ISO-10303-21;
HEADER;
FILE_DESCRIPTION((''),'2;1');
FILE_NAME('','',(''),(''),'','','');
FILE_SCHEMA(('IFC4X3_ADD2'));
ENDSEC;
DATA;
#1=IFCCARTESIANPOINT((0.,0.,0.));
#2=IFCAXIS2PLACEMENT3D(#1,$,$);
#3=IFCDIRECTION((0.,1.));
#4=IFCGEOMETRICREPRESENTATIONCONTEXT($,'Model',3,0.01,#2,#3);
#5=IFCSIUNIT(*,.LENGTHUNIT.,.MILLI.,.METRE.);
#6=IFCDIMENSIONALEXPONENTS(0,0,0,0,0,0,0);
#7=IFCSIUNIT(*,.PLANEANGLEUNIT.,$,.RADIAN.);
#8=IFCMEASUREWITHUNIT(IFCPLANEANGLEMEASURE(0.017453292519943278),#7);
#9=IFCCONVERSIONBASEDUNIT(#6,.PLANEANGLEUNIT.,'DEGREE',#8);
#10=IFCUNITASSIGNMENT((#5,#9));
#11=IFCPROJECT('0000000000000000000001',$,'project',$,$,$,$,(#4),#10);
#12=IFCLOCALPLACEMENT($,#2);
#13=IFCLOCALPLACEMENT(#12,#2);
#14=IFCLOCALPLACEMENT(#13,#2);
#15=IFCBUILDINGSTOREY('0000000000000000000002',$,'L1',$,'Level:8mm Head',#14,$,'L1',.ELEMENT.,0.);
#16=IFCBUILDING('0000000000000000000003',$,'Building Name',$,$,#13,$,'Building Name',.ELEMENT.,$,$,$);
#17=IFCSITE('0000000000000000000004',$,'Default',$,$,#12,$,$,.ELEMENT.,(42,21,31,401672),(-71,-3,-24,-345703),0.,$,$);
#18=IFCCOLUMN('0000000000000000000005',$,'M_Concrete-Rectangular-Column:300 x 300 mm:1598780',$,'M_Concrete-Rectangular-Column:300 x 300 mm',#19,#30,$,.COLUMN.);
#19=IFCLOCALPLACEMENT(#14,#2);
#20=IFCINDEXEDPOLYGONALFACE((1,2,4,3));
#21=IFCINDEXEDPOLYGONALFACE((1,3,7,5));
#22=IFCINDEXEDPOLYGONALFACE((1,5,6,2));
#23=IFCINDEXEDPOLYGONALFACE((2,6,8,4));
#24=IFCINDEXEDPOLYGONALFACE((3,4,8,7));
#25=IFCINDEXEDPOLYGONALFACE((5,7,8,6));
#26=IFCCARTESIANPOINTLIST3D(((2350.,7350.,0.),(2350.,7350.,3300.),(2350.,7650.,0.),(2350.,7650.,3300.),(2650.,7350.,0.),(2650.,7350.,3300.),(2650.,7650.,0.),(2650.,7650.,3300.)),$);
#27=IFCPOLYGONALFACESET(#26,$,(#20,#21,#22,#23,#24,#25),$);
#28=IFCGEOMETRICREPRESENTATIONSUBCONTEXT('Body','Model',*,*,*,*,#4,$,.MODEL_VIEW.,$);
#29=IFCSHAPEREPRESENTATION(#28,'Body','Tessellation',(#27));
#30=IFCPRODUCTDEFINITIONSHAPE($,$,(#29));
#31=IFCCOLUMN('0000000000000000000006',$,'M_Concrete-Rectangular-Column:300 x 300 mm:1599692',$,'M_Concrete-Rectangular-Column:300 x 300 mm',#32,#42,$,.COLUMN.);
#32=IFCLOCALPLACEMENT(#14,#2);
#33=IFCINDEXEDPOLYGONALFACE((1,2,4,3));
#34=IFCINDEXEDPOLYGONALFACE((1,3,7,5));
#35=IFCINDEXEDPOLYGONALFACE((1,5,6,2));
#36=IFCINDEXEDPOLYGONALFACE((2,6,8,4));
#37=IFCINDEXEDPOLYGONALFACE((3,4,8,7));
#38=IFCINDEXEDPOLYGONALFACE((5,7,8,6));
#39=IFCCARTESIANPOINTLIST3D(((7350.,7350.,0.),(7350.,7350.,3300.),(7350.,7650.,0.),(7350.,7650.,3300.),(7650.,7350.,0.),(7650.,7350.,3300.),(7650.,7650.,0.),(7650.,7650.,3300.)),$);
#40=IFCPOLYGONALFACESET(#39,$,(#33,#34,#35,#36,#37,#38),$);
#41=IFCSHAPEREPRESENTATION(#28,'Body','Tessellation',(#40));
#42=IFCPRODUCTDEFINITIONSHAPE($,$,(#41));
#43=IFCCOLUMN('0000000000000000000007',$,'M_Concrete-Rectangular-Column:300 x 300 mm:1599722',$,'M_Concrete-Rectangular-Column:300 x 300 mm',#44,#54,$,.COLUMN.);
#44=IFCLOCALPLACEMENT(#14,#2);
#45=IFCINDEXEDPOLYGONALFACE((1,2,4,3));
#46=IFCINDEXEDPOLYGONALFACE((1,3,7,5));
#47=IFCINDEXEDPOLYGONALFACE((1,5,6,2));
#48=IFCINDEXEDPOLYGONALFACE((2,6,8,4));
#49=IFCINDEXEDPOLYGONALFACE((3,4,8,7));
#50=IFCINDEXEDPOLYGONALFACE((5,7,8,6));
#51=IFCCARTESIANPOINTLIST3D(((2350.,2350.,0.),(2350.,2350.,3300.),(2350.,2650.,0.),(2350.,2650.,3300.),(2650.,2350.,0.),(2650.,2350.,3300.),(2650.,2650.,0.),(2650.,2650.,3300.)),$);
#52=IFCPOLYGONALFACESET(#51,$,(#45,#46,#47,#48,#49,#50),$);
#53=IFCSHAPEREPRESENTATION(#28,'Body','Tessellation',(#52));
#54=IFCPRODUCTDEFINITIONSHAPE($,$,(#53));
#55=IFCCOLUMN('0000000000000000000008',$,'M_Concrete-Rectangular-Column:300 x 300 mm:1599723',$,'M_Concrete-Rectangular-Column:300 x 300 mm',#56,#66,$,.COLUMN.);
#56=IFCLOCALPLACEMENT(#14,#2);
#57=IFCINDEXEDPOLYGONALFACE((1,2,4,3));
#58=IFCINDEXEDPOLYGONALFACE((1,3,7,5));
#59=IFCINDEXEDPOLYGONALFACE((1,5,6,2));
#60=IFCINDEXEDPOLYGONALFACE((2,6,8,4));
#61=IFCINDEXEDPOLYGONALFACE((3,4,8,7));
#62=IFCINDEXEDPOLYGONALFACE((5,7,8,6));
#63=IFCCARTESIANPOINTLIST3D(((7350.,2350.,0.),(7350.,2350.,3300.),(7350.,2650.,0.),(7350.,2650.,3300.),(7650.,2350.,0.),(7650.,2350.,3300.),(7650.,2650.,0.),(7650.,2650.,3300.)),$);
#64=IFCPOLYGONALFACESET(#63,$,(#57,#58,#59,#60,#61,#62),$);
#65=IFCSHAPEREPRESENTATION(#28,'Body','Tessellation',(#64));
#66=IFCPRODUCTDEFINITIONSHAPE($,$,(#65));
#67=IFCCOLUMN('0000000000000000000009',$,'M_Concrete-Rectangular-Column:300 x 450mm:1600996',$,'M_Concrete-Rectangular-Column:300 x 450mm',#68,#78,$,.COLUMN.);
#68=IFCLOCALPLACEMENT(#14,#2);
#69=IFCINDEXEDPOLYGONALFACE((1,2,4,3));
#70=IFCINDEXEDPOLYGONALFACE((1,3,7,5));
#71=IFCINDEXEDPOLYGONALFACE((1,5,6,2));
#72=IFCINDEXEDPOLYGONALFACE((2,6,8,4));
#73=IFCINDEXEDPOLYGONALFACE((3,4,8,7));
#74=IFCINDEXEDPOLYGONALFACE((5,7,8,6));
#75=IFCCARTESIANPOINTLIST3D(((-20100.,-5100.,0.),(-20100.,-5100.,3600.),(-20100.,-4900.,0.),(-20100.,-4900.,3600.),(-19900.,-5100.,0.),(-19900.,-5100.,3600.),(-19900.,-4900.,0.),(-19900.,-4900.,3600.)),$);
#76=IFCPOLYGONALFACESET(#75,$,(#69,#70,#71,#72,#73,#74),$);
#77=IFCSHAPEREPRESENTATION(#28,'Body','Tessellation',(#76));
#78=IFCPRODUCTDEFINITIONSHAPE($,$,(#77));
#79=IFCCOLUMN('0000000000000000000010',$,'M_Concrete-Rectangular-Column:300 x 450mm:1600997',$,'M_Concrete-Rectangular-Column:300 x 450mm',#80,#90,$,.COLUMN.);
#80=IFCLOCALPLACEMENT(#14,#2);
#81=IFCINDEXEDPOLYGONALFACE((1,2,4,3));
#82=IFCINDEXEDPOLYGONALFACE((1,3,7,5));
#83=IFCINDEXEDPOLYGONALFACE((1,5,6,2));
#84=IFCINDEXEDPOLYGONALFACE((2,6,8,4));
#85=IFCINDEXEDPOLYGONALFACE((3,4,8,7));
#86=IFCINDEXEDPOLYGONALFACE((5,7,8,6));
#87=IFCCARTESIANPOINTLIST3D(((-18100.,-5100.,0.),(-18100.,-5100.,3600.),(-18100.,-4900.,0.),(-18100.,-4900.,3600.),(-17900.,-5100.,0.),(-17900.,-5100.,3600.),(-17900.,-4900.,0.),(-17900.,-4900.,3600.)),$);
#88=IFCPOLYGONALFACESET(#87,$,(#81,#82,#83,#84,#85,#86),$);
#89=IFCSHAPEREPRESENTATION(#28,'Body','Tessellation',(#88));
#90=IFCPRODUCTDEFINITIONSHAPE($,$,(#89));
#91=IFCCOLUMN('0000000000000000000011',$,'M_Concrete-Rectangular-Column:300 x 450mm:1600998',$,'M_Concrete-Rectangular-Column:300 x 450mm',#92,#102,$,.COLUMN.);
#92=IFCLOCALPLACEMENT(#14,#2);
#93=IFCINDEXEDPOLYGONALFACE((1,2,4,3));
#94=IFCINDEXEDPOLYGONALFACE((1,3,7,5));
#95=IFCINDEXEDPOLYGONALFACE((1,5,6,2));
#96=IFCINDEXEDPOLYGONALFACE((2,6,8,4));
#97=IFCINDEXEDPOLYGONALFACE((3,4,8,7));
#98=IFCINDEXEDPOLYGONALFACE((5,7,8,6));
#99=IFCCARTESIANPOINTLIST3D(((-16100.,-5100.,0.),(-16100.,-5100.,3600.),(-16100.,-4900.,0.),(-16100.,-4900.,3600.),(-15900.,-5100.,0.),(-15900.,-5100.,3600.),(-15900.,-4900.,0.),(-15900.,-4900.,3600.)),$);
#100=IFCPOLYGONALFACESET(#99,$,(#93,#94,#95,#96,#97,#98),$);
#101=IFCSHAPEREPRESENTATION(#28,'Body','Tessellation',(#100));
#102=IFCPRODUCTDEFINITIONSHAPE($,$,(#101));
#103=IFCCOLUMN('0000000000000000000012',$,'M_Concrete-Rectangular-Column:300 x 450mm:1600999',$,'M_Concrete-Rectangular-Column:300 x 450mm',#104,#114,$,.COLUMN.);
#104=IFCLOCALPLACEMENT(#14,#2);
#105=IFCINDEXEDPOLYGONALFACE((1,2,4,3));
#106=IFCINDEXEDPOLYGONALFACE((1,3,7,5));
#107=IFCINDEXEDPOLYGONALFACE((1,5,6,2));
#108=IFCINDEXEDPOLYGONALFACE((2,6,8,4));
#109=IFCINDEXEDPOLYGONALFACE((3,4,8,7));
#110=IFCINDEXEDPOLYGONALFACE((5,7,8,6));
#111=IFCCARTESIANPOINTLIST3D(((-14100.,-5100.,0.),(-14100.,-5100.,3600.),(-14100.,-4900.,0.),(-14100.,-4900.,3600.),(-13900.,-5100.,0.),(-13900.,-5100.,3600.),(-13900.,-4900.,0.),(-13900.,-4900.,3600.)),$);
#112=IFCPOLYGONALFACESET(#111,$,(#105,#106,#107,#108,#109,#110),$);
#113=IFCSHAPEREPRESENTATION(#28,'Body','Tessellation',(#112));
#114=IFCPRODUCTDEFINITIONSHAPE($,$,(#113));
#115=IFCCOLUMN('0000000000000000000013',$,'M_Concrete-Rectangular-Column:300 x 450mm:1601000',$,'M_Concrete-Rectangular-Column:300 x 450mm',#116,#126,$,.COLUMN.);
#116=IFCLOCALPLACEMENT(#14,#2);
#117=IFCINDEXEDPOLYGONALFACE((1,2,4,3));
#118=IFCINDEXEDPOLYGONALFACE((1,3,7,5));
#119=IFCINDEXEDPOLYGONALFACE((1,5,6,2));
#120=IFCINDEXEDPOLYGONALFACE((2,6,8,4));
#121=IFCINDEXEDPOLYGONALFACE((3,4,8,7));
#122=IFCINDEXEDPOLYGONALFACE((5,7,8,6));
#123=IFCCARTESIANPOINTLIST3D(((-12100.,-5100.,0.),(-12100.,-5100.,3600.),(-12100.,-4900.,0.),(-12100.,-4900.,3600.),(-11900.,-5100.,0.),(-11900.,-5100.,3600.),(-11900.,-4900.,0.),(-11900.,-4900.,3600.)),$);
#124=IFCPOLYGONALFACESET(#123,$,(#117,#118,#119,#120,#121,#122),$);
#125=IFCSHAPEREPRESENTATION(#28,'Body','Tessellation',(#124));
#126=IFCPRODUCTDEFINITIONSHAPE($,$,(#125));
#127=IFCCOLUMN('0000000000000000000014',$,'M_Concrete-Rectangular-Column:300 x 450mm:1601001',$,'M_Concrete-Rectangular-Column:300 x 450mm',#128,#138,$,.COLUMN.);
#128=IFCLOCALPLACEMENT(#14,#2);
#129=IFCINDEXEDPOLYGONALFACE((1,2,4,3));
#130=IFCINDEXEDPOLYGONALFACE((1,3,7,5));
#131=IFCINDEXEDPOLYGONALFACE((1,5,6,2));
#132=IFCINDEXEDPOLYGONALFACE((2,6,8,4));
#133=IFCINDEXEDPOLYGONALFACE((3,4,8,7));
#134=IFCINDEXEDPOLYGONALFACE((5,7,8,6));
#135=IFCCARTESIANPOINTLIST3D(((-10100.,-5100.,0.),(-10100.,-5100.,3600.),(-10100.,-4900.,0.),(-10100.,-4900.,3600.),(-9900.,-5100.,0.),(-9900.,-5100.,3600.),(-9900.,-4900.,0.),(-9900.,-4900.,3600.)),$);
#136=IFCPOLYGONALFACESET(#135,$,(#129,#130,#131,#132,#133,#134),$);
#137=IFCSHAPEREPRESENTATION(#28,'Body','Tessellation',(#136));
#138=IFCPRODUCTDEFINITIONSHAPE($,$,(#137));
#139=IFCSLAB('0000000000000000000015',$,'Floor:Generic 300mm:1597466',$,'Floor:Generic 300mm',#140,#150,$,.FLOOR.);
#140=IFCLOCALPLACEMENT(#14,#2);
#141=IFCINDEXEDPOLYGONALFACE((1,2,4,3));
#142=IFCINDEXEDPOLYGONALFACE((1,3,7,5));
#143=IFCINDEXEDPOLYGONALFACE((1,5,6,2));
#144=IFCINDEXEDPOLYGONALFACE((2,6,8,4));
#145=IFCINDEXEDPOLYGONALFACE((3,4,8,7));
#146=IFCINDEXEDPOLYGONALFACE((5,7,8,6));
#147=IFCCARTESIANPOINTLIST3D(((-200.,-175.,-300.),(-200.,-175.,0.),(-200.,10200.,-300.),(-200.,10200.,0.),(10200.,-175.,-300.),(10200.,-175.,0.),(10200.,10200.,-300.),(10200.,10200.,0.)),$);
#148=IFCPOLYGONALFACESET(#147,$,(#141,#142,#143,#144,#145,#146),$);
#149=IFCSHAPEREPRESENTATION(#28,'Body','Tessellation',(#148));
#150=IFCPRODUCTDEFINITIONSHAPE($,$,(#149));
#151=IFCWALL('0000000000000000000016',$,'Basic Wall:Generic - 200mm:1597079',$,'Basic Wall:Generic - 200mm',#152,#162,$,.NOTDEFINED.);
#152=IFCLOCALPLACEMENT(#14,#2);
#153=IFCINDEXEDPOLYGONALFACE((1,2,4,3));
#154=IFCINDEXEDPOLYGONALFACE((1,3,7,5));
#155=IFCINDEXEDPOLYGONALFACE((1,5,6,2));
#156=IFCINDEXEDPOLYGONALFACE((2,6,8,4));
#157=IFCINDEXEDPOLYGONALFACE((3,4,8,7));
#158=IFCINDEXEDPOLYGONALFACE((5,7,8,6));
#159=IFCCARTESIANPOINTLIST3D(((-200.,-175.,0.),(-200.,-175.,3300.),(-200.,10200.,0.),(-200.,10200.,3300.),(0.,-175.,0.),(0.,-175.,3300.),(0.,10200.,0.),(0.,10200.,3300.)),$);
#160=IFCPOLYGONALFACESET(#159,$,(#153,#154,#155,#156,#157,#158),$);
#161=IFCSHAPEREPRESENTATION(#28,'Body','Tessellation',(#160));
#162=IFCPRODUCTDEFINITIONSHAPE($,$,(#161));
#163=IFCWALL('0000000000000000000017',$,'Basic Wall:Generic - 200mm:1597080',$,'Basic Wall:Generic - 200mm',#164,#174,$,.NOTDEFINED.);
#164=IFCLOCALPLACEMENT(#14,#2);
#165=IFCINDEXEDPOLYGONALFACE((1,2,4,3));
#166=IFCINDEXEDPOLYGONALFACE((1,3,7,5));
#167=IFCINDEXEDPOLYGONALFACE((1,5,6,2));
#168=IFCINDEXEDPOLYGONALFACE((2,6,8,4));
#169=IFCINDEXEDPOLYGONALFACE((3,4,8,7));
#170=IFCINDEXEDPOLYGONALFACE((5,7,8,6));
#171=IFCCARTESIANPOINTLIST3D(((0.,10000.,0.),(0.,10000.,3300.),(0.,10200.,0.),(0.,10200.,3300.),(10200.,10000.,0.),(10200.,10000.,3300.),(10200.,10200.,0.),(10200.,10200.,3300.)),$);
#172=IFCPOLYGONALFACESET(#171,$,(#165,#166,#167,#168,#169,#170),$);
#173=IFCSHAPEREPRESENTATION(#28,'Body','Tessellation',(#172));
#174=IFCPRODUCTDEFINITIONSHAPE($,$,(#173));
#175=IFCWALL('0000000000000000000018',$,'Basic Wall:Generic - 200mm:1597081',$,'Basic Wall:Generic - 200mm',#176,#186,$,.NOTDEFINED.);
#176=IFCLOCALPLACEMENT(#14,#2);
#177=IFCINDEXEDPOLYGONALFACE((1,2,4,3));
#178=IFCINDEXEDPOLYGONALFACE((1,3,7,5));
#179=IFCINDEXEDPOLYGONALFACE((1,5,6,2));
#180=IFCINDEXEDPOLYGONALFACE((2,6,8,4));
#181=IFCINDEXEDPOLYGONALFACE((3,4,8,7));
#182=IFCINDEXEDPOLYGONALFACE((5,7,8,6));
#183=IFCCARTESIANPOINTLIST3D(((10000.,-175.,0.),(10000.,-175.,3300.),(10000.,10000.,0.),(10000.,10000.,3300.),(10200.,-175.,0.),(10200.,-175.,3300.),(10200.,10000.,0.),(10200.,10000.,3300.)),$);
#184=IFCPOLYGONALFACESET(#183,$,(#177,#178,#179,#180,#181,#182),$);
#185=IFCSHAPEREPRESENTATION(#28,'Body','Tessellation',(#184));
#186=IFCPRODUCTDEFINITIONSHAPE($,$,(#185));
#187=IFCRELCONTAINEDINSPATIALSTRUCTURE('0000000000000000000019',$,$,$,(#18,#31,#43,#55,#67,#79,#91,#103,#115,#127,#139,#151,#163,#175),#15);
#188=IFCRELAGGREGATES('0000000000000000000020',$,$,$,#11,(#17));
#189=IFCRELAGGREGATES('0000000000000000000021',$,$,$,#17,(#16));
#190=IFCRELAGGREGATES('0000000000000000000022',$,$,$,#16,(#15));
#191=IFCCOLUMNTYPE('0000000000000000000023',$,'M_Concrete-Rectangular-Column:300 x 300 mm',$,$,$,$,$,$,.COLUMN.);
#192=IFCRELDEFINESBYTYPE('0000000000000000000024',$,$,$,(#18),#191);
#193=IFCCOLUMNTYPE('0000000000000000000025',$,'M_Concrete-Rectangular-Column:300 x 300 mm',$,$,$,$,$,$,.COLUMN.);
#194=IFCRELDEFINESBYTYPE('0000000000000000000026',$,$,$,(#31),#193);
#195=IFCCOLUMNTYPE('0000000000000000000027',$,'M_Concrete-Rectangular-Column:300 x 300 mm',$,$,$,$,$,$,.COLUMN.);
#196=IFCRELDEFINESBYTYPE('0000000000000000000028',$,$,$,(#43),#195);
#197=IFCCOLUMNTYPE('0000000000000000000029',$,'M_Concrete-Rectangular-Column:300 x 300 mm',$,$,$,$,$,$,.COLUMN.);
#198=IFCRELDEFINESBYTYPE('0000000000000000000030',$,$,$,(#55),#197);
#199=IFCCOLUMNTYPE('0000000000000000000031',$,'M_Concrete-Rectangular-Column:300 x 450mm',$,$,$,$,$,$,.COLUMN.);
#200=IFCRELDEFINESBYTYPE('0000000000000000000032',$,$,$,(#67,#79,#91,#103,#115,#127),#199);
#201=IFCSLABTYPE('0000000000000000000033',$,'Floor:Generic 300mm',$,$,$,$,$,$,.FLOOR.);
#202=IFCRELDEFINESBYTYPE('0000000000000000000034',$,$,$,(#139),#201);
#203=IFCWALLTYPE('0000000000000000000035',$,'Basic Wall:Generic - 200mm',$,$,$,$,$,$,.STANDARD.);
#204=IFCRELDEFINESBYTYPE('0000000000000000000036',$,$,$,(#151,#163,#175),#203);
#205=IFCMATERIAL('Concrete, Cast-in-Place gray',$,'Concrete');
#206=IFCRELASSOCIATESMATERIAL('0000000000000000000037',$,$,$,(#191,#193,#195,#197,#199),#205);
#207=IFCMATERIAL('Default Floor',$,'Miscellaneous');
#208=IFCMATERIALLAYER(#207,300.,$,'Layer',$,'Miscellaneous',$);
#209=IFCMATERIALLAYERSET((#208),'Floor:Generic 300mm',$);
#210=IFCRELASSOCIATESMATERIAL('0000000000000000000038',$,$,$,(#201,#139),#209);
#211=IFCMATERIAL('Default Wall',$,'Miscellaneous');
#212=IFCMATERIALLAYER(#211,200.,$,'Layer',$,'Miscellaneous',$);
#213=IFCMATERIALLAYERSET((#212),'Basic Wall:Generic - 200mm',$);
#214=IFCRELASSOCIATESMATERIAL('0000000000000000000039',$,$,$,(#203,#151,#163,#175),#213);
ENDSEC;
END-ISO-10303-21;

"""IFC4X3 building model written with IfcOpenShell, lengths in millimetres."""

from ifc_helpers import new_model, entity, si_unit, converted_unit, direction, frame, frame_2d, origin, origin_2d_with_axis, place, context, subcontext, project, spatial, rectangle, extrude, source, transform, mapped, material, layer, layer_set, layer_usage, material_profile, profile_set, type_object, type_shapes, element, save


model = new_model("IFC4X3")

# Units and contexts
model_context = context("Model", 3, precision=0.01, world=origin(), true_north=direction((0.0, 1.0)))
body_context = subcontext(model_context, "Body", "Model", "MODEL_VIEW")
ifc_project = project(units=[si_unit("LENGTHUNIT", "METRE", prefix="MILLI"), converted_unit("PLANEANGLEUNIT", "DEGREE", entity("IfcPlaneAngleMeasure", 0.017453292519943278), si_unit("PLANEANGLEUNIT", "RADIAN"), dimensions=[0, 0, 0, 0, 0, 0, 0])], contexts=[model_context])

# Site, building, storey
site_placement = place(None, origin())
site = spatial("IfcSite", under=ifc_project, at=site_placement, Name="Default", CompositionType="ELEMENT", RefLatitude=(42, 21, 31, 401672), RefLongitude=(-71, -3, -24, -345703), RefElevation=0.0)
building_placement = place(site_placement, origin())
building = spatial("IfcBuilding", under=site, at=building_placement, Name="Building Name", LongName="Building Name", CompositionType="ELEMENT")
storey_placement = place(building_placement, origin())
storey = spatial("IfcBuildingStorey", under=building, at=storey_placement, Name="L1", ObjectType="Level:8mm Head", LongName="L1", CompositionType="ELEMENT", Elevation=0.0)

# Columns
ifc_material_1 = material(Name="Concrete, Cast-in-Place gray", Category="Concrete")
ifc_material_profile_1 = material_profile(ifc_material_1, rectangle(XDim=300.0, YDim=300.0, at=origin_2d_with_axis()), Name="300 x 300 mm")
ifc_profile_set_1 = profile_set([ifc_material_profile_1], Name="300 x 300 mm")
column_type_1 = type_object("IfcColumnType", Name="M_Concrete-Rectangular-Column:300 x 300 mm", PredefinedType="COLUMN", material=ifc_profile_set_1)
shared_shape_1 = source(origin(), body_context, "Body", "SweptSolid", [
    extrude(rectangle(XDim=300.0, YDim=300.0, at=origin_2d_with_axis()), frame((2500.0, 7500.0, 0.0)), (0.0, 0.0, 1.0), 3300.0),
])
type_shapes(column_type_1, [shared_shape_1])
column_1_placement = place(storey_placement, origin())
element("IfcColumn", 1, at=column_1_placement, inside=storey, type_object=column_type_1, Name="M_Concrete-Rectangular-Column:300 x 300 mm:1598780", ObjectType="M_Concrete-Rectangular-Column:300 x 300 mm", PredefinedType="COLUMN", context=body_context, shape_type="MappedRepresentation", body=[
    mapped(shared_shape_1, transform((0.0, 0.0, 0.0), scale=1.0)),
])
column_type_2 = type_object("IfcColumnType", Name="M_Concrete-Rectangular-Column:300 x 300 mm", PredefinedType="COLUMN", material=ifc_profile_set_1)
shared_shape_2 = source(origin(), body_context, "Body", "SweptSolid", [
    extrude(rectangle(XDim=300.0, YDim=300.0, at=origin_2d_with_axis()), frame((7500.0, 7500.0, 0.0)), (0.0, 0.0, 1.0), 3300.0),
])
type_shapes(column_type_2, [shared_shape_2])
column_2_placement = place(storey_placement, origin())
element("IfcColumn", 2, at=column_2_placement, inside=storey, type_object=column_type_2, Name="M_Concrete-Rectangular-Column:300 x 300 mm:1599692", ObjectType="M_Concrete-Rectangular-Column:300 x 300 mm", PredefinedType="COLUMN", context=body_context, shape_type="MappedRepresentation", body=[
    mapped(shared_shape_2, transform((0.0, 0.0, 0.0), scale=1.0)),
])
column_type_3 = type_object("IfcColumnType", Name="M_Concrete-Rectangular-Column:300 x 300 mm", PredefinedType="COLUMN", material=ifc_profile_set_1)
shared_shape_3 = source(origin(), body_context, "Body", "SweptSolid", [
    extrude(rectangle(XDim=300.0, YDim=300.0, at=origin_2d_with_axis()), frame((2500.0, 2500.0, 0.0)), (0.0, 0.0, 1.0), 3300.0),
])
type_shapes(column_type_3, [shared_shape_3])
column_3_placement = place(storey_placement, origin())
element("IfcColumn", 3, at=column_3_placement, inside=storey, type_object=column_type_3, Name="M_Concrete-Rectangular-Column:300 x 300 mm:1599722", ObjectType="M_Concrete-Rectangular-Column:300 x 300 mm", PredefinedType="COLUMN", context=body_context, shape_type="MappedRepresentation", body=[
    mapped(shared_shape_3, transform((0.0, 0.0, 0.0), scale=1.0)),
])
column_type_4 = type_object("IfcColumnType", Name="M_Concrete-Rectangular-Column:300 x 300 mm", PredefinedType="COLUMN", material=ifc_profile_set_1)
shared_shape_4 = source(origin(), body_context, "Body", "SweptSolid", [
    extrude(rectangle(XDim=300.0, YDim=300.0, at=origin_2d_with_axis()), frame((7500.0, 2500.0, 0.0)), (0.0, 0.0, 1.0), 3300.0),
])
type_shapes(column_type_4, [shared_shape_4])
column_4_placement = place(storey_placement, origin())
element("IfcColumn", 4, at=column_4_placement, inside=storey, type_object=column_type_4, Name="M_Concrete-Rectangular-Column:300 x 300 mm:1599723", ObjectType="M_Concrete-Rectangular-Column:300 x 300 mm", PredefinedType="COLUMN", context=body_context, shape_type="MappedRepresentation", body=[
    mapped(shared_shape_4, transform((0.0, 0.0, 0.0), scale=1.0)),
])
ifc_material_profile_2 = material_profile(ifc_material_1, rectangle(XDim=200.0, YDim=200.0, at=origin_2d_with_axis()), Name="300 x 450mm")
ifc_profile_set_2 = profile_set([ifc_material_profile_2], Name="300 x 450mm")
column_type_5 = type_object("IfcColumnType", Name="M_Concrete-Rectangular-Column:300 x 450mm", PredefinedType="COLUMN", material=ifc_profile_set_2)
shared_shape_5 = source(origin(), body_context, "Body", "SweptSolid", [
    extrude(rectangle(XDim=200.0, YDim=200.0, at=origin_2d_with_axis()), frame((0.0, 0.0, 0.0), z_axis=(0.0, 0.0, 1.0), x_axis=(-1.0, 0.0, 0.0)), (0.0, 0.0, 1.0), 3600.0),
])
type_shapes(column_type_5, [shared_shape_5])
for number, where, z_axis, x_axis, name in (
    (5, (-20000.0, -5000.0, 0.0), (0.0, 0.0, 1.0), (0.0, -1.0, 0.0), "M_Concrete-Rectangular-Column:300 x 450mm:1600996"),
    (6, (-18000.0, -5000.0, 0.0), (0.0, 0.0, 1.0), (0.0, -1.0, 0.0), "M_Concrete-Rectangular-Column:300 x 450mm:1600997"),
    (7, (-16000.0, -5000.0, 0.0), (0.0, 0.0, 1.0), (0.0, -1.0, 0.0), "M_Concrete-Rectangular-Column:300 x 450mm:1600998"),
    (8, (-14000.0, -5000.0, 0.0), (0.0, 0.0, 1.0), (0.0, -1.0, 0.0), "M_Concrete-Rectangular-Column:300 x 450mm:1600999"),
    (9, (-12000.0, -5000.0, 0.0), (0.0, 0.0, 1.0), (0.0, -1.0, 0.0), "M_Concrete-Rectangular-Column:300 x 450mm:1601000"),
    (10, (-10000.0, -5000.0, 0.0), (0.0, 0.0, 1.0), (0.0, -1.0, 0.0), "M_Concrete-Rectangular-Column:300 x 450mm:1601001"),
):
    element("IfcColumn", number, at=place(storey_placement, frame(where, z_axis=z_axis, x_axis=x_axis)), inside=storey, type_object=column_type_5, Name=name, ObjectType="M_Concrete-Rectangular-Column:300 x 450mm", PredefinedType="COLUMN", context=body_context, shape_type="MappedRepresentation", body=[
        mapped(shared_shape_5, transform((0.0, 0.0, 0.0), scale=1.0)),
    ])

# Slab
ifc_material_2 = material(Name="Default Floor", Category="Miscellaneous")
ifc_layer_1 = layer(ifc_material_2, 300.0, Name="Layer", Category="Miscellaneous")
ifc_layer_set_1 = layer_set([ifc_layer_1], Name="Floor:Generic 300mm")
ifc_layer_usage = layer_usage(ifc_layer_set_1, "AXIS3", "POSITIVE", 0.0)
slab_type = type_object("IfcSlabType", Name="Floor:Generic 300mm", PredefinedType="FLOOR", material=ifc_layer_set_1)
slab_placement = place(storey_placement, origin())
element("IfcSlab", 11, at=slab_placement, inside=storey, type_object=slab_type, material=ifc_layer_usage, Name="Floor:Generic 300mm:1597466", ObjectType="Floor:Generic 300mm", PredefinedType="FLOOR", context=body_context, shape_type="SweptSolid", body=[
    extrude(rectangle(XDim=10375.0, YDim=10400.0, at=origin_2d_with_axis()), frame((5000.0, 5012.5, 0.0), z_axis=(0.0, 0.0, -1.0), x_axis=(0.0, 1.0, 0.0)), (0.0, 0.0, 1.0), 300.0),
])

# Walls
ifc_material_3 = material(Name="Default Wall", Category="Miscellaneous")
ifc_layer_2 = layer(ifc_material_3, 200.0, Name="Layer", Category="Miscellaneous")
ifc_layer_set_2 = layer_set([ifc_layer_2], Name="Basic Wall:Generic - 200mm")
wall_type_1 = type_object("IfcWallType", Name="Basic Wall:Generic - 200mm", PredefinedType="STANDARD", material=ifc_layer_set_2)
wall_1_placement = place(storey_placement, frame((-100.0, 10200.0, 0.0), z_axis=(0.0, 0.0, 1.0), x_axis=(0.0, -1.0, 0.0)))
element("IfcWall", 12, at=wall_1_placement, inside=storey, type_object=wall_type_1, material=ifc_layer_set_2, Name="Basic Wall:Generic - 200mm:1597079", ObjectType="Basic Wall:Generic - 200mm", PredefinedType="NOTDEFINED", context=body_context, shape_type="SweptSolid", body=[
    extrude(rectangle(XDim=10375.0, YDim=200.0, at=frame_2d((5187.5, 0.0), x_axis=(-1.0, 0.0))), origin(), (0.0, 0.0, 1.0), 3300.0),
])
wall_2_placement = place(storey_placement, frame((10200.0, 10100.0, 0.0), z_axis=(0.0, 0.0, 1.0), x_axis=(-1.0, 0.0, 0.0)))
element("IfcWall", 13, at=wall_2_placement, inside=storey, type_object=wall_type_1, material=ifc_layer_set_2, Name="Basic Wall:Generic - 200mm:1597080", ObjectType="Basic Wall:Generic - 200mm", PredefinedType="NOTDEFINED", context=body_context, shape_type="SweptSolid", body=[
    extrude(rectangle(XDim=10200.0, YDim=200.0, at=frame_2d((5100.0, 0.0), x_axis=(-1.0, 0.0))), origin(), (0.0, 0.0, 1.0), 3300.0),
])
wall_3_placement = place(storey_placement, frame((10100.0, -175.0, 0.0), z_axis=(0.0, 0.0, 1.0), x_axis=(0.0, 1.0, 0.0)))
element("IfcWall", 14, at=wall_3_placement, inside=storey, type_object=wall_type_1, material=ifc_layer_set_2, Name="Basic Wall:Generic - 200mm:1597081", ObjectType="Basic Wall:Generic - 200mm", PredefinedType="NOTDEFINED", context=body_context, shape_type="SweptSolid", body=[
    extrude(rectangle(XDim=10175.0, YDim=200.0, at=frame_2d((5087.5, 0.0), x_axis=(-1.0, 0.0))), origin(), (0.0, 0.0, 1.0), 3300.0),
])

save(model, "model.ifc")
